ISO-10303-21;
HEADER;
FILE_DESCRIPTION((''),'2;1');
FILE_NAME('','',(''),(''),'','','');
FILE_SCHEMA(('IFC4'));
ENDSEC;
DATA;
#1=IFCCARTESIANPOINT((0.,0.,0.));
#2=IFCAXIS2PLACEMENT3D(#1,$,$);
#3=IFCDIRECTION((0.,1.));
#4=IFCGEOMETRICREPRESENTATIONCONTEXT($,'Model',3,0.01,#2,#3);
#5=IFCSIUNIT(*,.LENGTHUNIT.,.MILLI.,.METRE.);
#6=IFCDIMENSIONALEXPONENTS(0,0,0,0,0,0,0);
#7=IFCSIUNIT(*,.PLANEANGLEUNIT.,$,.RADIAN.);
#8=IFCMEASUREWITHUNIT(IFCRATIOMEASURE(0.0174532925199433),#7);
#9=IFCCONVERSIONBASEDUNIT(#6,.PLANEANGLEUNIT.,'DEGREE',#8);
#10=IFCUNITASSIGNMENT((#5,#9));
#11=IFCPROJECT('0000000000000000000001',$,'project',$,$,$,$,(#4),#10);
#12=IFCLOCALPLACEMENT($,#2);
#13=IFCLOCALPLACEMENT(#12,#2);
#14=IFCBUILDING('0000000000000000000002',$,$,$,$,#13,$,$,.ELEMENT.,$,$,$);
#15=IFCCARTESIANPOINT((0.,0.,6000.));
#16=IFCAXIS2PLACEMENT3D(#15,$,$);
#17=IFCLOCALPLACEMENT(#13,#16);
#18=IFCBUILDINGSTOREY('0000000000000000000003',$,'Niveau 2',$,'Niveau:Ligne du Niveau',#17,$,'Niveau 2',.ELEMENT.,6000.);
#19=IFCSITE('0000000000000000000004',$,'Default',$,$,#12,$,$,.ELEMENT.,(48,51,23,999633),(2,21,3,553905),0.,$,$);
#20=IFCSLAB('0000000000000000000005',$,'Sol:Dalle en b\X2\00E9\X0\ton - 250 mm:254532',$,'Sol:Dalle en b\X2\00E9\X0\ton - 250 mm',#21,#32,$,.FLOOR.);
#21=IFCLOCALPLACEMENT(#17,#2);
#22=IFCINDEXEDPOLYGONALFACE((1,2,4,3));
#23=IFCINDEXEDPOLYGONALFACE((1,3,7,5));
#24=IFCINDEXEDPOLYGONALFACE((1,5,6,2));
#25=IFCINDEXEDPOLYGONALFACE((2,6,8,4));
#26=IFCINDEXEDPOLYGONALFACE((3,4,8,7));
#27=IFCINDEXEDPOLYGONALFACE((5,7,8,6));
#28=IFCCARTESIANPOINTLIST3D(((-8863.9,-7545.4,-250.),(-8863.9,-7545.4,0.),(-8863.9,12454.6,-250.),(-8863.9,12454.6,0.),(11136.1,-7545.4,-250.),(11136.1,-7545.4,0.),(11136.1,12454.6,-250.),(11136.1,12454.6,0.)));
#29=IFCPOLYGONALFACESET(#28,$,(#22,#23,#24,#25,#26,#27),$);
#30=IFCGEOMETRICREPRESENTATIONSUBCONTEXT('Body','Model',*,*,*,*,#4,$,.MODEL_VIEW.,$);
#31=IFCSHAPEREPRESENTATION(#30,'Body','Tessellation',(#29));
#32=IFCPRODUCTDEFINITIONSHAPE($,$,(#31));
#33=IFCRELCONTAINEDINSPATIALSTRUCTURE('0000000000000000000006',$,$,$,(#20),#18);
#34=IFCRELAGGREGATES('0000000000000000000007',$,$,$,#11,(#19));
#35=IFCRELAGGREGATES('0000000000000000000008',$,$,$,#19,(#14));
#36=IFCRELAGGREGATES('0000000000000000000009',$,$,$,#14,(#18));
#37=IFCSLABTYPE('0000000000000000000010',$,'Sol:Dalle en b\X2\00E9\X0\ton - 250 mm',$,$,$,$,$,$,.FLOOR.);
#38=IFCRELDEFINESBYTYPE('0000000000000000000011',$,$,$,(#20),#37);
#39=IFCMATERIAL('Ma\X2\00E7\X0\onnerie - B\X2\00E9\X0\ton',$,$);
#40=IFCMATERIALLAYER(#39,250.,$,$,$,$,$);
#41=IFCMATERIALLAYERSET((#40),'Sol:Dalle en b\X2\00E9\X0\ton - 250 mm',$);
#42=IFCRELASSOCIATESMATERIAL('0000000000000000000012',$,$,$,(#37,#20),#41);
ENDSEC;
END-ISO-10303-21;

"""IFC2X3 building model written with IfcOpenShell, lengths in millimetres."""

from ifc_helpers import new_model, entity, si_unit, converted_unit, direction, frame, origin, origin_2d_with_axis, place, context, subcontext, project, spatial, rectangle, extrude, material, layer, layer_set, layer_usage, type_object, element, save


model = new_model("IFC2X3")

# Units and contexts
model_context = context("Model", 3, precision=0.01, world=origin(), true_north=direction((0.0, 1.0)))
body_context = subcontext(model_context, "Body", "Model", "MODEL_VIEW")
ifc_project = project(units=[si_unit("LENGTHUNIT", "METRE", prefix="MILLI"), converted_unit("PLANEANGLEUNIT", "DEGREE", entity("IfcRatioMeasure", 0.0174532925199433), si_unit("PLANEANGLEUNIT", "RADIAN"), dimensions=[0, 0, 0, 0, 0, 0, 0])], contexts=[model_context])

# Site, building, storey
site_placement = place(None, origin())
site = spatial("IfcSite", under=ifc_project, at=site_placement, Name="Default", CompositionType="ELEMENT", RefLatitude=(48, 51, 23, 999633), RefLongitude=(2, 21, 3, 553905), RefElevation=0.0)
building_placement = place(site_placement, origin())
building = spatial("IfcBuilding", under=site, at=building_placement, CompositionType="ELEMENT")
storey_placement = place(building_placement, frame((0.0, 0.0, 6000.0)))
storey = spatial("IfcBuildingStorey", under=building, at=storey_placement, Name="Niveau 2", ObjectType="Niveau:Ligne du Niveau", LongName="Niveau 2", CompositionType="ELEMENT", Elevation=6000.0)

# Slab
ifc_material = material(Name="Maçonnerie - Béton")
ifc_layer = layer(ifc_material, 250.0)
ifc_layer_set = layer_set([ifc_layer], Name="Sol:Dalle en béton - 250 mm")
ifc_layer_usage = layer_usage(ifc_layer_set, "AXIS3", "POSITIVE", 0.0)
slab_type = type_object("IfcSlabType", Name="Sol:Dalle en béton - 250 mm", PredefinedType="FLOOR", material=ifc_layer_set)
slab_placement = place(storey_placement, origin())
element("IfcSlab", 1, at=slab_placement, inside=storey, type_object=slab_type, material=ifc_layer_usage, Name="Sol:Dalle en béton - 250 mm:254532", ObjectType="Sol:Dalle en béton - 250 mm", PredefinedType="FLOOR", context=body_context, shape_type="SweptSolid", body=[
    extrude(rectangle(XDim=20000.0, YDim=20000.0, at=origin_2d_with_axis()), frame((1136.1, 2454.6, 0.0), z_axis=(0.0, 0.0, -1.0), x_axis=(0.0, 1.0, 0.0)), (0.0, 0.0, 1.0), 250.0),
])

save(model, "model.ifc")
